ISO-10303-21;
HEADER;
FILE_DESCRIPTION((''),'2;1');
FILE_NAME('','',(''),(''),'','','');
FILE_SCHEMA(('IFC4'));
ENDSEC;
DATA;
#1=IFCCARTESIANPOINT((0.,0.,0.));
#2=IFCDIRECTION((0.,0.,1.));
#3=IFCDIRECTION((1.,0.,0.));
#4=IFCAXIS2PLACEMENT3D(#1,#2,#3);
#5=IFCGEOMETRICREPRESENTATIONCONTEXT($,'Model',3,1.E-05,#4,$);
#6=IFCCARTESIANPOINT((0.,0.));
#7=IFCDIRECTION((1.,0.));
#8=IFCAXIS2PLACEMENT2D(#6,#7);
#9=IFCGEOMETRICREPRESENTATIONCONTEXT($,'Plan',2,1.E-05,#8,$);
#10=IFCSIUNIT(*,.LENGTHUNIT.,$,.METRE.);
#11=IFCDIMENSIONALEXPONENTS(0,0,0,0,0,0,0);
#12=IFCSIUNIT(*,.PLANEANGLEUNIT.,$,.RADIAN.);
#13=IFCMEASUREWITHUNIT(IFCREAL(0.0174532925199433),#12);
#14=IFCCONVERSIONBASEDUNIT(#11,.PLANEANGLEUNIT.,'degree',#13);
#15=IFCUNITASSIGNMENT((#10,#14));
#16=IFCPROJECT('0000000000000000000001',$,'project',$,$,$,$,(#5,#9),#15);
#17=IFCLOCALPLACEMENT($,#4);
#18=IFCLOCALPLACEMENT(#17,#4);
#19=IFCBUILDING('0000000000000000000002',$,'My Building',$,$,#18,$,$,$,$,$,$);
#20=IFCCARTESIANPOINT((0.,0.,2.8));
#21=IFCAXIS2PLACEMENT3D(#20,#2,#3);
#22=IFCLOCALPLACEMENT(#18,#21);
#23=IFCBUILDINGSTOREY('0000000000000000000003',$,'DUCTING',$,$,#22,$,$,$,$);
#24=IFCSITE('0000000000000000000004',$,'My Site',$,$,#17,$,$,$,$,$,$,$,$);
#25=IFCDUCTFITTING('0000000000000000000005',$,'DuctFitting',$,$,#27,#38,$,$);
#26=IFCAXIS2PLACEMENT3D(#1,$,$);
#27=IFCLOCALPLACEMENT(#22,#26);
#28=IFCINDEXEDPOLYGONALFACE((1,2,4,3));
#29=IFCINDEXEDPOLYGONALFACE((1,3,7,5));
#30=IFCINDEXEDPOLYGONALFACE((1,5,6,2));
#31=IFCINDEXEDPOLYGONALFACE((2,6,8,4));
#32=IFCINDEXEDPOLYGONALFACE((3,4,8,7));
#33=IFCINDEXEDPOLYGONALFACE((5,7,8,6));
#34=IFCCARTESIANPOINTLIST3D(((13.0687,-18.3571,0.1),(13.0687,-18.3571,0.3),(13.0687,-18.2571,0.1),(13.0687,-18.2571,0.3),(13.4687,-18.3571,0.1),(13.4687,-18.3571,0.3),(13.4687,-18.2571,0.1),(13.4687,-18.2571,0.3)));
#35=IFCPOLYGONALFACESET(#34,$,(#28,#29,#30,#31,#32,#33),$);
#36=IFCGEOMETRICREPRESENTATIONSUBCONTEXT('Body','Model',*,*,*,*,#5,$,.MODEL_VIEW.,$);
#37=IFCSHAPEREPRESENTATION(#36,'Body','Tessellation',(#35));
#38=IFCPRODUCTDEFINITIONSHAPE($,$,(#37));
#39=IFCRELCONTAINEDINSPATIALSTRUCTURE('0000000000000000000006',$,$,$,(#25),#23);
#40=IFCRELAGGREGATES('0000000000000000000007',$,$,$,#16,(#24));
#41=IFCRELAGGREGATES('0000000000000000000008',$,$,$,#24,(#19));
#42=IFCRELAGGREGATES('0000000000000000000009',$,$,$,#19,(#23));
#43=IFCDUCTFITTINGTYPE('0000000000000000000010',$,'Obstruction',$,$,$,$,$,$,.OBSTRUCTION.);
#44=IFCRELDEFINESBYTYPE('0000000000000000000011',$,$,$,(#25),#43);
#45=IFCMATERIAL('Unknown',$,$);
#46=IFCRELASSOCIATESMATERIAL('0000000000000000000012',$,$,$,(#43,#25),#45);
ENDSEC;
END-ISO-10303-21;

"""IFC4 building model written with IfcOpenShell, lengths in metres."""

from ifc_helpers import new_model, entity, si_unit, converted_unit, frame, origin_with_axes, origin_2d_with_axis, place, context, subcontext, project, spatial, rectangle, extrude, material, material_profile, profile_set, profile_usage, type_object, element, save


model = new_model("IFC4")

# Units and contexts
model_context = context("Model", 3, precision=1e-05, world=origin_with_axes())
plan_context = context("Plan", 2, precision=1e-05, world=origin_2d_with_axis())
body_context = subcontext(model_context, "Body", "Model", "MODEL_VIEW")
ifc_project = project(units=[si_unit("LENGTHUNIT", "METRE"), converted_unit("PLANEANGLEUNIT", "degree", entity("IfcReal", 0.0174532925199433), si_unit("PLANEANGLEUNIT", "RADIAN"), dimensions=[0, 0, 0, 0, 0, 0, 0])], contexts=[model_context, plan_context])

# Site, building, storey
site_placement = place(None, origin_with_axes())
site = spatial("IfcSite", under=ifc_project, at=site_placement, Name="My Site")
building_placement = place(site_placement, origin_with_axes())
building = spatial("IfcBuilding", under=site, at=building_placement, Name="My Building")
storey_placement = place(building_placement, frame((0.0, 0.0, 2.8), z_axis=(0.0, 0.0, 1.0), x_axis=(1.0, 0.0, 0.0)))
storey = spatial("IfcBuildingStorey", under=building, at=storey_placement, Name="DUCTING")

# Shared definitions
ifc_material = material(Name="Unknown")

# Duct fitting
ifc_material_profile_1 = material_profile(ifc_material, rectangle(XDim=0.4, YDim=0.2))
ifc_profile_set_1 = profile_set([ifc_material_profile_1])
duct_fitting_type_1 = type_object("IfcDuctFittingType", Name="Obstruction", PredefinedType="OBSTRUCTION", material=ifc_profile_set_1)
ifc_profile_usage_1 = profile_usage(ifc_profile_set_1, cardinal=5)
duct_fitting_1_placement = place(storey_placement, frame((13.2687, -18.2571, 0.2), z_axis=(0.0, -1.0, 0.0), x_axis=(1.0, 0.0, 0.0)))
element("IfcDuctFitting", 1, at=duct_fitting_1_placement, inside=storey, type_object=duct_fitting_type_1, material=ifc_profile_usage_1, Name="DuctFitting", context=body_context, shape_type="SweptSolid", body=[
    extrude(rectangle(XDim=0.4, YDim=0.2), origin_with_axes(), (0.0, 0.0, 1.0), 0.1),
])

save(model, "model.ifc")
